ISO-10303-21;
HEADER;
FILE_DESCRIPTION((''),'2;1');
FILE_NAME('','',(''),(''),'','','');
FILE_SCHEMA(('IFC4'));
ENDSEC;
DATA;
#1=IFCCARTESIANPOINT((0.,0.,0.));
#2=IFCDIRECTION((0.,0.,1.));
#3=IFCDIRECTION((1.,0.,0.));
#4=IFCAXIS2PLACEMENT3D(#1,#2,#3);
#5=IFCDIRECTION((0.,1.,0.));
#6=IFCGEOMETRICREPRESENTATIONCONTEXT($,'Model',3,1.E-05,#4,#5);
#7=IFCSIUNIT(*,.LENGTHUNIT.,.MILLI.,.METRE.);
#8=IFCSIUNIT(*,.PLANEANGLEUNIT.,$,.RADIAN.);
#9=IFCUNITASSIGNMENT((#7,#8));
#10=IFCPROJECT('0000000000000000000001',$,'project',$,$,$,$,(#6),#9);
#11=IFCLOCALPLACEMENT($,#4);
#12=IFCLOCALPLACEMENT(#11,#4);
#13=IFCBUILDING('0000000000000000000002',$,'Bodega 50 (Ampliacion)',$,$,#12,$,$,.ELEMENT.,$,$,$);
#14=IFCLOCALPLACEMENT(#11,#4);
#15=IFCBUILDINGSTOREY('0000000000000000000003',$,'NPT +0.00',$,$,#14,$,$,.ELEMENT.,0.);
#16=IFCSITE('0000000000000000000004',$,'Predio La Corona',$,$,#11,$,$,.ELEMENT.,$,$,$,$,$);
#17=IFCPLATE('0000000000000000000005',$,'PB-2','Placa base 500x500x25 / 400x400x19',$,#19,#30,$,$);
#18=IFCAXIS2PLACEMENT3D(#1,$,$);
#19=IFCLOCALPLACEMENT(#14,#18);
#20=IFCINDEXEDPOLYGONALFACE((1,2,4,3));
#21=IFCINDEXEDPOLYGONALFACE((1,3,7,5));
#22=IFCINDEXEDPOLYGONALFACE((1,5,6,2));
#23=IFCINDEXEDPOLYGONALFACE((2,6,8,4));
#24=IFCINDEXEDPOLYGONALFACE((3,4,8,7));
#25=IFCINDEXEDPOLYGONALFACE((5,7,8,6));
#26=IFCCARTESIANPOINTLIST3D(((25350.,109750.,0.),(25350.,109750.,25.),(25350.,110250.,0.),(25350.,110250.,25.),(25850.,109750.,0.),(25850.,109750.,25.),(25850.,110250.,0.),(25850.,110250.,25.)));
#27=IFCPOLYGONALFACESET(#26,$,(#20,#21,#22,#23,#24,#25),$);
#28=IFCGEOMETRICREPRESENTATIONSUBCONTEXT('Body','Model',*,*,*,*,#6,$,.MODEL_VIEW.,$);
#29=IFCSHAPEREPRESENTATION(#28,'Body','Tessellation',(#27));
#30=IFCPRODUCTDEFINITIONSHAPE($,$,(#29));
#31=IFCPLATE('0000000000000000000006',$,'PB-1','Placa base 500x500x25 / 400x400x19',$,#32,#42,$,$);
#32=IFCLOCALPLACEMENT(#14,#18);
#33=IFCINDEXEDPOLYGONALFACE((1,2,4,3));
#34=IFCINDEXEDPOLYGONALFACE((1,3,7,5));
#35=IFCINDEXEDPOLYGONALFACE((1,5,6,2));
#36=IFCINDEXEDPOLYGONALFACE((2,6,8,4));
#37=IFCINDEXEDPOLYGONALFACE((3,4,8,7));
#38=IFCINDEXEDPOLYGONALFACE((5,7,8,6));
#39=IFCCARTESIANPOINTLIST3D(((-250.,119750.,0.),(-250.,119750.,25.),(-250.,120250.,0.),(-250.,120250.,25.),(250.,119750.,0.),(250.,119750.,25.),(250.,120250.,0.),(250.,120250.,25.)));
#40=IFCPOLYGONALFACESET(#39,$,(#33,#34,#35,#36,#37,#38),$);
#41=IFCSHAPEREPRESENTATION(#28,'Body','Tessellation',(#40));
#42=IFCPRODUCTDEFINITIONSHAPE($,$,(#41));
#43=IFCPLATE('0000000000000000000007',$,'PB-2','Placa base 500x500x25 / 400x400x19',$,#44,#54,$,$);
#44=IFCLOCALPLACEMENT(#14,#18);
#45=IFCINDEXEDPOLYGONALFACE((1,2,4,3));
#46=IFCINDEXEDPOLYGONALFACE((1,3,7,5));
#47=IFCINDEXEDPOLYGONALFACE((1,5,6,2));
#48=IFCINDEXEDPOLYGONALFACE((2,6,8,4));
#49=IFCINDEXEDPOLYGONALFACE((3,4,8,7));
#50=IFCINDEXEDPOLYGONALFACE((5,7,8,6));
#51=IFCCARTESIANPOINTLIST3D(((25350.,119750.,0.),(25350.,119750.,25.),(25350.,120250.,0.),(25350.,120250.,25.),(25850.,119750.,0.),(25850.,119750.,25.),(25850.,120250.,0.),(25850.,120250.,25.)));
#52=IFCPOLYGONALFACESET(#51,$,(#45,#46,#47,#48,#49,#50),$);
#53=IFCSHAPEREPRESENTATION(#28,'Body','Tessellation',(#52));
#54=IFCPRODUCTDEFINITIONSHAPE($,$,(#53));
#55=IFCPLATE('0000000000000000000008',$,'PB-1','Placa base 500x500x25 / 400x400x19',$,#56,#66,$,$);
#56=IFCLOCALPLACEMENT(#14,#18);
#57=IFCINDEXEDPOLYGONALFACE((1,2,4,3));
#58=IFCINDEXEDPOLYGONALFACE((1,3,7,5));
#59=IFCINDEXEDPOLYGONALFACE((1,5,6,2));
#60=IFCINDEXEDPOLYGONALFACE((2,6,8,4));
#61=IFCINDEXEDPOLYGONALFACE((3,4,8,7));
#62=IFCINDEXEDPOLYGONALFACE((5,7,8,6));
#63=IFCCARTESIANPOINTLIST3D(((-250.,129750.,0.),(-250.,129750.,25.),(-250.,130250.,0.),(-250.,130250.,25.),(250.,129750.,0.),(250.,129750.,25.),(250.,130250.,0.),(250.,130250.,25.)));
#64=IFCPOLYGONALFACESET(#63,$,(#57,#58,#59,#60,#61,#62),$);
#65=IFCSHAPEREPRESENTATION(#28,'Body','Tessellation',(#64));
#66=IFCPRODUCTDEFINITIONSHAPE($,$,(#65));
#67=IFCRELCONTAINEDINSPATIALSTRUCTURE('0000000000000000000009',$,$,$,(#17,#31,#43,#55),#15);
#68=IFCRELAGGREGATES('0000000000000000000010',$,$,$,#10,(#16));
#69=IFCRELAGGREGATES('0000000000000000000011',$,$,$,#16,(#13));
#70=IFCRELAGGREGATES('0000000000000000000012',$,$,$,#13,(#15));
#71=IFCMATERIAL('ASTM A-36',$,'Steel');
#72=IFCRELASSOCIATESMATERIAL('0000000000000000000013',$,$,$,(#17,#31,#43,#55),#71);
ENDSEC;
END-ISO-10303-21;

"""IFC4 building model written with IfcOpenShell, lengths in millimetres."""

from ifc_helpers import new_model, si_unit, direction, frame, origin_with_axes, origin_2d, place, context, subcontext, project, spatial, rectangle, extrude, material, element, save


model = new_model("IFC4")

# Units and contexts
model_context = context("Model", 3, precision=1e-05, world=origin_with_axes(), true_north=direction((0.0, 1.0, 0.0)))
body_context = subcontext(model_context, "Body", "Model", "MODEL_VIEW")
ifc_project = project(units=[si_unit("LENGTHUNIT", "METRE", prefix="MILLI"), si_unit("PLANEANGLEUNIT", "RADIAN")], contexts=[model_context])

# Site, building, storey
site_placement = place(None, origin_with_axes())
site = spatial("IfcSite", under=ifc_project, at=site_placement, Name="Predio La Corona", CompositionType="ELEMENT")
building_placement = place(site_placement, origin_with_axes())
building = spatial("IfcBuilding", under=site, at=building_placement, Name="Bodega 50 (Ampliacion)", CompositionType="ELEMENT")
storey_placement = place(site_placement, origin_with_axes())
storey = spatial("IfcBuildingStorey", under=building, at=storey_placement, Name="NPT +0.00", CompositionType="ELEMENT", Elevation=0.0)

# Shared definitions
ifc_material = material(Name="ASTM A-36", Category="Steel")

# Plates
for number, where, z_axis, x_axis, name in (
    (1, (25600.0, 110000.0, 0.0), (0.0, 0.0, 1.0), (1.0, 0.0, 0.0), "PB-2"),
    (2, (0.0, 120000.0, 0.0), (0.0, 0.0, 1.0), (1.0, 0.0, 0.0), "PB-1"),
    (3, (25600.0, 120000.0, 0.0), (0.0, 0.0, 1.0), (1.0, 0.0, 0.0), "PB-2"),
    (4, (0.0, 130000.0, 0.0), (0.0, 0.0, 1.0), (1.0, 0.0, 0.0), "PB-1"),
):
    element("IfcPlate", number, at=place(storey_placement, frame(where, z_axis=z_axis, x_axis=x_axis)), inside=storey, material=ifc_material, Name=name, Description="Placa base 500x500x25 / 400x400x19", context=body_context, shape_type="SweptSolid", body=[
        extrude(rectangle(XDim=500.0, YDim=500.0, at=origin_2d()), origin_with_axes(), (0.0, 0.0, 1.0), 25.0),
    ])

save(model, "model.ifc")
